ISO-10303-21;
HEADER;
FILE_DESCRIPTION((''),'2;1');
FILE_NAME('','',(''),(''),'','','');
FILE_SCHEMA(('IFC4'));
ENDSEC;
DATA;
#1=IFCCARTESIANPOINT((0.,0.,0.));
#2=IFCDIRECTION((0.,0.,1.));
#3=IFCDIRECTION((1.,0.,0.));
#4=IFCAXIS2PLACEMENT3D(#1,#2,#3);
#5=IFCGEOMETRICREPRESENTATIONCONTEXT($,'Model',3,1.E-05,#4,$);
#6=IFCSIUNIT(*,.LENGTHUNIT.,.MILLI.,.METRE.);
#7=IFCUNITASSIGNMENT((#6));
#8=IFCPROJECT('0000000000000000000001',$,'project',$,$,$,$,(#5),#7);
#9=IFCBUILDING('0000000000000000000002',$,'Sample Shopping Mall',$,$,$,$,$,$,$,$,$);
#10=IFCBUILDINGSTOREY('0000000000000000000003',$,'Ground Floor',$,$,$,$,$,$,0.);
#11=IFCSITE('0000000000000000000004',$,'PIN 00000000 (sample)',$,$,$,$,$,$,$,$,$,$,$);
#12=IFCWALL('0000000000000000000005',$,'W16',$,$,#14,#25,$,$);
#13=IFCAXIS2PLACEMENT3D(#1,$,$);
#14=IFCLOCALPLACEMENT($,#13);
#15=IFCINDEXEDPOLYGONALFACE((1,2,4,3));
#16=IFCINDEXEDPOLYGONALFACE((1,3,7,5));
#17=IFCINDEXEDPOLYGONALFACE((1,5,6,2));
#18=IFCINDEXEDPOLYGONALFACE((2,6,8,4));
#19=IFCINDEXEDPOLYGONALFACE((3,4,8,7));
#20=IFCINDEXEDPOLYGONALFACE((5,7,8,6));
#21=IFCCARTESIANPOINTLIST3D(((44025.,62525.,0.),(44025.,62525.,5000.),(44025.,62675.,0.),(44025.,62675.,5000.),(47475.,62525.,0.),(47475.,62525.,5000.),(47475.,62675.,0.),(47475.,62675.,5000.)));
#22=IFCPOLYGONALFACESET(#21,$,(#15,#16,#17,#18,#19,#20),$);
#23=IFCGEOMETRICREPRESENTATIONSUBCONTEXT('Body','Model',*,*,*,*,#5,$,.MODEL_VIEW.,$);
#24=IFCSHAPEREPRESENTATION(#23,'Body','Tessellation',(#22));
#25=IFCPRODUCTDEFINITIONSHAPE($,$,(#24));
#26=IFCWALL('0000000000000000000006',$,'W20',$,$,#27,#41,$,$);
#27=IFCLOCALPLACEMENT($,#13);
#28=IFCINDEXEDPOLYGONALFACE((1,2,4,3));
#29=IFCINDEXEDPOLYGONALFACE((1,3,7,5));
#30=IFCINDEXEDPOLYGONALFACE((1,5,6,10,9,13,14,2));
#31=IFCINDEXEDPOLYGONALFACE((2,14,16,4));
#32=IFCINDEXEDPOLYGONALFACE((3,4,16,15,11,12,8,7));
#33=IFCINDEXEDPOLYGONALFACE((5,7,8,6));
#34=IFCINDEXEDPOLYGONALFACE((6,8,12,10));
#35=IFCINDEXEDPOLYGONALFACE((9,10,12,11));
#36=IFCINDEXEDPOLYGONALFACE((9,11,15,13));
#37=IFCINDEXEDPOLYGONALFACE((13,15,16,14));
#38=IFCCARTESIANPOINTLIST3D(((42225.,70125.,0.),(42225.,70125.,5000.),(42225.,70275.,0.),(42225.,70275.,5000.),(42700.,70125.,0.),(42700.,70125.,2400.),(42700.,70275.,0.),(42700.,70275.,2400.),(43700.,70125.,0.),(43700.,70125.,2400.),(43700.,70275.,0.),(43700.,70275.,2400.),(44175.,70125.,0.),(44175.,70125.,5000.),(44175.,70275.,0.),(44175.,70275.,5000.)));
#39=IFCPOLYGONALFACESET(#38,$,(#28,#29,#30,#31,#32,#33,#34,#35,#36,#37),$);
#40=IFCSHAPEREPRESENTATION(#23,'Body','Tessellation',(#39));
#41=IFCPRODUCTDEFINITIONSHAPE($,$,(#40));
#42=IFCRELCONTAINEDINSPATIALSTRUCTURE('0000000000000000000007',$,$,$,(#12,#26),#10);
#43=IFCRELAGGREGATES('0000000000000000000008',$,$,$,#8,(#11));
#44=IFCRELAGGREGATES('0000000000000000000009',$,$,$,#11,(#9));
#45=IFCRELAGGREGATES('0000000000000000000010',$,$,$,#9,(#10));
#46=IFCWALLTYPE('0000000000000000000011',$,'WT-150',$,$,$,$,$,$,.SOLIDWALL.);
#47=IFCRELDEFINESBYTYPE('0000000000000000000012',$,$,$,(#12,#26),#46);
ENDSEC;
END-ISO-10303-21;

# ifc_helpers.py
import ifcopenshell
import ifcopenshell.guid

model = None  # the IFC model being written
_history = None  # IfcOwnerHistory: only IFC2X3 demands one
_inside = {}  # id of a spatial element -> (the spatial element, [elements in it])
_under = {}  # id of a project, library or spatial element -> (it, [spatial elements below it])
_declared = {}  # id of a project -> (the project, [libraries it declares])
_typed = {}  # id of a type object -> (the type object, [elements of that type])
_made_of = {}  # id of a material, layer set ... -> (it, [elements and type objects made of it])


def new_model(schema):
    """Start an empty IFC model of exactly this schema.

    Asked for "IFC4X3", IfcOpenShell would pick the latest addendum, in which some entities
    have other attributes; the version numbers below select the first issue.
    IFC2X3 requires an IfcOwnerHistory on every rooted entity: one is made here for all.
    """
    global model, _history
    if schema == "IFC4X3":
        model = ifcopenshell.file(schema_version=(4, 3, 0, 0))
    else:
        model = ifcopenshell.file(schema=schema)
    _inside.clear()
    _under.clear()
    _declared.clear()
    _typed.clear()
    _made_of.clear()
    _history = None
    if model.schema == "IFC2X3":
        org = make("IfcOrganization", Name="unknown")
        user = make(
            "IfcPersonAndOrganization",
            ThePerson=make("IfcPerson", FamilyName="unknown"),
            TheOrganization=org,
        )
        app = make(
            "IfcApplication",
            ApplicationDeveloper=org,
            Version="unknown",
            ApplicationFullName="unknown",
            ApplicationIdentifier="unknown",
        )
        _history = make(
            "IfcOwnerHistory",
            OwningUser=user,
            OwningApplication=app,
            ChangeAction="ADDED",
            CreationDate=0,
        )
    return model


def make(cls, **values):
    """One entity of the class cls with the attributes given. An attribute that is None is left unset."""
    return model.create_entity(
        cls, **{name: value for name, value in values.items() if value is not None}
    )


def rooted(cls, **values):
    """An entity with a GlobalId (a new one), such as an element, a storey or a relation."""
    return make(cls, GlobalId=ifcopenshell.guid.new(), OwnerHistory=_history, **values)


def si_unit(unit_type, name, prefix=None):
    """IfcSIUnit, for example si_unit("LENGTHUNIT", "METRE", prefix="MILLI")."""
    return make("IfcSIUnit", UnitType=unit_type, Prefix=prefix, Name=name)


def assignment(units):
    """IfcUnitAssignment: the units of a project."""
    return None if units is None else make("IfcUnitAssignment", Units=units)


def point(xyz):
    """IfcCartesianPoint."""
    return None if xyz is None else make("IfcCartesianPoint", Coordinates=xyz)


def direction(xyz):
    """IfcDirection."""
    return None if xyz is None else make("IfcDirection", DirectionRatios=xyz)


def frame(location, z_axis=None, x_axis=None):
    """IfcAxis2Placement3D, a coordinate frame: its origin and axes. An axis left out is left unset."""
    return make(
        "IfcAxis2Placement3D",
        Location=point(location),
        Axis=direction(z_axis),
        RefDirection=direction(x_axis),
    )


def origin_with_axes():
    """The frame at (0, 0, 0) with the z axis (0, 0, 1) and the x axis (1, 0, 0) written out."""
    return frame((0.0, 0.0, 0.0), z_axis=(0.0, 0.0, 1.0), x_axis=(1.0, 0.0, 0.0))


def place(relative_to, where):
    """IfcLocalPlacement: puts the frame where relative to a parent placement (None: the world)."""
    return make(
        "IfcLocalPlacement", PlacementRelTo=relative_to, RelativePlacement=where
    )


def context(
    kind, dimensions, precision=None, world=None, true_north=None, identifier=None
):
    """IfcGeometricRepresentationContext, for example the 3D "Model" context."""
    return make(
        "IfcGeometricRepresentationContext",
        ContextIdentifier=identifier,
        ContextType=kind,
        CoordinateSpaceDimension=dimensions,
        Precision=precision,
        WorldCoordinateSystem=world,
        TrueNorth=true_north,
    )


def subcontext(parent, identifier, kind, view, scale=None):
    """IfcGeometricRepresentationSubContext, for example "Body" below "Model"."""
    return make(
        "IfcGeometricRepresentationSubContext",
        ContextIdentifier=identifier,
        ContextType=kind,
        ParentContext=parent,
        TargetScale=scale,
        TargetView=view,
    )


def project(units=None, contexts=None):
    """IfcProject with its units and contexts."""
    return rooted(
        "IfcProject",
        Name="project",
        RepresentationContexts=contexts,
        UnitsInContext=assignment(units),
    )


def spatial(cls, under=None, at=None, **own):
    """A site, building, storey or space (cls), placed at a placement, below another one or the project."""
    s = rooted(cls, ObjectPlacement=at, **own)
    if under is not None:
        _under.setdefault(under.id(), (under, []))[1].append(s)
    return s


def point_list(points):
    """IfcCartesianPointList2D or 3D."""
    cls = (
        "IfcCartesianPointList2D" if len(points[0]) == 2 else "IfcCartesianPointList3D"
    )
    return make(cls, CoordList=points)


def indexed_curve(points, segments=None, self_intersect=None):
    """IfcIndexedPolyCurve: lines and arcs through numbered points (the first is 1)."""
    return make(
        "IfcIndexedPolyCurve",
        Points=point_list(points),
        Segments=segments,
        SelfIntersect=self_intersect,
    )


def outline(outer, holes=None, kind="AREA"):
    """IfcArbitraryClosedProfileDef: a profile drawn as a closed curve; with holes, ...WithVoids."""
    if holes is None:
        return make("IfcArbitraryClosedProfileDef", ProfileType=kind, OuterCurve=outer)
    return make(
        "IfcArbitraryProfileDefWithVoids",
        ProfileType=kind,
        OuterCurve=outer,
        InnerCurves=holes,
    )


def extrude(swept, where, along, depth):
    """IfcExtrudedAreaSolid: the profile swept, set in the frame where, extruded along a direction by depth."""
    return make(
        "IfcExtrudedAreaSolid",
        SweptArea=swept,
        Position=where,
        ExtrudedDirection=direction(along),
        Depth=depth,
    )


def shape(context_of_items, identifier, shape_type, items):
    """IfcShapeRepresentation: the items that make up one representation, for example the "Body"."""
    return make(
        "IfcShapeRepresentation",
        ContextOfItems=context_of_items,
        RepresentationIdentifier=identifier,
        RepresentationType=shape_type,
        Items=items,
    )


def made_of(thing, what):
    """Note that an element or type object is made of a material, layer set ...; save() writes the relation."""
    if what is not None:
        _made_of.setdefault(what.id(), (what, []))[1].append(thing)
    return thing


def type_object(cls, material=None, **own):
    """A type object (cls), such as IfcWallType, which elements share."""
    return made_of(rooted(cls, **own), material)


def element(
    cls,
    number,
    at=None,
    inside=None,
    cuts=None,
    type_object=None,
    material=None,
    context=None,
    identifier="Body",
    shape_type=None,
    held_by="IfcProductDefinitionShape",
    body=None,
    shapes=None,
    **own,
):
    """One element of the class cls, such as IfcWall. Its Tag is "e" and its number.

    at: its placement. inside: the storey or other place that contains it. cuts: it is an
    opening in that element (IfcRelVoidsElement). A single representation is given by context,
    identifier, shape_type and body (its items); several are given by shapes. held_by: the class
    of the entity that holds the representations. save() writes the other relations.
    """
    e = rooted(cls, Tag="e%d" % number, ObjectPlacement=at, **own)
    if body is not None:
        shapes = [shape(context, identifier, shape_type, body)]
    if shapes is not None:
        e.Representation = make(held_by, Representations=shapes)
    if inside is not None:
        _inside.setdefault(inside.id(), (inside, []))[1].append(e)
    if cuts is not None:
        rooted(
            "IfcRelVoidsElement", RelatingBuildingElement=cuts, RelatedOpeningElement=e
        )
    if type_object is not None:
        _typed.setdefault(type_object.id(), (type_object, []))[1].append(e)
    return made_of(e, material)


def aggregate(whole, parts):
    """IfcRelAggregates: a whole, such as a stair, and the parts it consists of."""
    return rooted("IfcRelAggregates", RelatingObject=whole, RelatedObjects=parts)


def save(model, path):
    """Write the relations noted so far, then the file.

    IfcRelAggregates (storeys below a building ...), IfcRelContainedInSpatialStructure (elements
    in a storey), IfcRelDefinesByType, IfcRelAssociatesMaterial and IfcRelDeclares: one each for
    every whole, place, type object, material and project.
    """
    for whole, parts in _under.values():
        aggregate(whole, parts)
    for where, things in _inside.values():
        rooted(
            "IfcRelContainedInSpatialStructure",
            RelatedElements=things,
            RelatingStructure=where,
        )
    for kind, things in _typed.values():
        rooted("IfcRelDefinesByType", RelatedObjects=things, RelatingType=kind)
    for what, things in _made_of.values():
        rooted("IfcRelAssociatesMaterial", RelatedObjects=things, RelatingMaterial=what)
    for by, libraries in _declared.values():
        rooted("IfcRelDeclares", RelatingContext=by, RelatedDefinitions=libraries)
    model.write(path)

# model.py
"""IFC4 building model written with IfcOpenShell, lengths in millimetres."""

from ifc_helpers import new_model, si_unit, frame, origin_with_axes, place, context, subcontext, project, spatial, indexed_curve, outline, extrude, type_object, element, save


model = new_model("IFC4")

# Units and contexts
model_context = context("Model", 3, precision=1e-05, world=origin_with_axes())
body_context = subcontext(model_context, "Body", "Model", "MODEL_VIEW")
ifc_project = project(units=[si_unit("LENGTHUNIT", "METRE", prefix="MILLI")], contexts=[model_context])

# Site, building, storey
site = spatial("IfcSite", under=ifc_project, Name="PIN 00000000 (sample)")
building = spatial("IfcBuilding", under=site, Name="Sample Shopping Mall")
storey = spatial("IfcBuildingStorey", under=building, Name="Ground Floor", Elevation=0.0)

# Wall
wall_type_1 = type_object("IfcWallType", Name="WT-150", PredefinedType="SOLIDWALL")
for number, where, z_axis, x_axis, name in (
    (1, (44025.0, 62525.0, 0.0), (0.0, 0.0, 1.0), (1.0, 0.0, 0.0), "W16"),
):
    element("IfcWall", number, at=place(None, frame(where, z_axis=z_axis, x_axis=x_axis)), inside=storey, type_object=wall_type_1, Name=name, context=body_context, shape_type="SweptSolid", body=[
        extrude(outline(indexed_curve([(0.0, 0.0), (0.0, 150.0), (3450.0, 150.0), (3450.0, 0.0), (0.0, 0.0)], self_intersect=False)), origin_with_axes(), (0.0, 0.0, 1.0), 5000.0),
    ])

# Wall, opening
wall_1_placement = place(None, frame((42225.0, 70125.0, 0.0), z_axis=(0.0, 0.0, 1.0), x_axis=(1.0, 0.0, 0.0)))
wall_1 = element("IfcWall", 2, at=wall_1_placement, inside=storey, type_object=wall_type_1, Name="W20", context=body_context, shape_type="SweptSolid", body=[
    extrude(outline(indexed_curve([(0.0, 0.0), (0.0, 150.0), (1950.0, 150.0), (1950.0, 0.0), (0.0, 0.0)], self_intersect=False)), origin_with_axes(), (0.0, 0.0, 1.0), 5000.0),
])
opening_1_placement = place(wall_1_placement, frame((475.0, -100.0, 0.0), z_axis=(0.0, 0.0, 1.0), x_axis=(1.0, 0.0, 0.0)))
element("IfcOpeningElement", 3, at=opening_1_placement, cuts=wall_1, context=body_context, shape_type="SweptSolid", body=[
    extrude(outline(indexed_curve([(0.0, 0.0), (0.0, 350.0), (1000.0, 350.0), (1000.0, 0.0), (0.0, 0.0)], self_intersect=False)), origin_with_axes(), (0.0, 0.0, 1.0), 2400.0),
])

save(model, "model.ifc")
